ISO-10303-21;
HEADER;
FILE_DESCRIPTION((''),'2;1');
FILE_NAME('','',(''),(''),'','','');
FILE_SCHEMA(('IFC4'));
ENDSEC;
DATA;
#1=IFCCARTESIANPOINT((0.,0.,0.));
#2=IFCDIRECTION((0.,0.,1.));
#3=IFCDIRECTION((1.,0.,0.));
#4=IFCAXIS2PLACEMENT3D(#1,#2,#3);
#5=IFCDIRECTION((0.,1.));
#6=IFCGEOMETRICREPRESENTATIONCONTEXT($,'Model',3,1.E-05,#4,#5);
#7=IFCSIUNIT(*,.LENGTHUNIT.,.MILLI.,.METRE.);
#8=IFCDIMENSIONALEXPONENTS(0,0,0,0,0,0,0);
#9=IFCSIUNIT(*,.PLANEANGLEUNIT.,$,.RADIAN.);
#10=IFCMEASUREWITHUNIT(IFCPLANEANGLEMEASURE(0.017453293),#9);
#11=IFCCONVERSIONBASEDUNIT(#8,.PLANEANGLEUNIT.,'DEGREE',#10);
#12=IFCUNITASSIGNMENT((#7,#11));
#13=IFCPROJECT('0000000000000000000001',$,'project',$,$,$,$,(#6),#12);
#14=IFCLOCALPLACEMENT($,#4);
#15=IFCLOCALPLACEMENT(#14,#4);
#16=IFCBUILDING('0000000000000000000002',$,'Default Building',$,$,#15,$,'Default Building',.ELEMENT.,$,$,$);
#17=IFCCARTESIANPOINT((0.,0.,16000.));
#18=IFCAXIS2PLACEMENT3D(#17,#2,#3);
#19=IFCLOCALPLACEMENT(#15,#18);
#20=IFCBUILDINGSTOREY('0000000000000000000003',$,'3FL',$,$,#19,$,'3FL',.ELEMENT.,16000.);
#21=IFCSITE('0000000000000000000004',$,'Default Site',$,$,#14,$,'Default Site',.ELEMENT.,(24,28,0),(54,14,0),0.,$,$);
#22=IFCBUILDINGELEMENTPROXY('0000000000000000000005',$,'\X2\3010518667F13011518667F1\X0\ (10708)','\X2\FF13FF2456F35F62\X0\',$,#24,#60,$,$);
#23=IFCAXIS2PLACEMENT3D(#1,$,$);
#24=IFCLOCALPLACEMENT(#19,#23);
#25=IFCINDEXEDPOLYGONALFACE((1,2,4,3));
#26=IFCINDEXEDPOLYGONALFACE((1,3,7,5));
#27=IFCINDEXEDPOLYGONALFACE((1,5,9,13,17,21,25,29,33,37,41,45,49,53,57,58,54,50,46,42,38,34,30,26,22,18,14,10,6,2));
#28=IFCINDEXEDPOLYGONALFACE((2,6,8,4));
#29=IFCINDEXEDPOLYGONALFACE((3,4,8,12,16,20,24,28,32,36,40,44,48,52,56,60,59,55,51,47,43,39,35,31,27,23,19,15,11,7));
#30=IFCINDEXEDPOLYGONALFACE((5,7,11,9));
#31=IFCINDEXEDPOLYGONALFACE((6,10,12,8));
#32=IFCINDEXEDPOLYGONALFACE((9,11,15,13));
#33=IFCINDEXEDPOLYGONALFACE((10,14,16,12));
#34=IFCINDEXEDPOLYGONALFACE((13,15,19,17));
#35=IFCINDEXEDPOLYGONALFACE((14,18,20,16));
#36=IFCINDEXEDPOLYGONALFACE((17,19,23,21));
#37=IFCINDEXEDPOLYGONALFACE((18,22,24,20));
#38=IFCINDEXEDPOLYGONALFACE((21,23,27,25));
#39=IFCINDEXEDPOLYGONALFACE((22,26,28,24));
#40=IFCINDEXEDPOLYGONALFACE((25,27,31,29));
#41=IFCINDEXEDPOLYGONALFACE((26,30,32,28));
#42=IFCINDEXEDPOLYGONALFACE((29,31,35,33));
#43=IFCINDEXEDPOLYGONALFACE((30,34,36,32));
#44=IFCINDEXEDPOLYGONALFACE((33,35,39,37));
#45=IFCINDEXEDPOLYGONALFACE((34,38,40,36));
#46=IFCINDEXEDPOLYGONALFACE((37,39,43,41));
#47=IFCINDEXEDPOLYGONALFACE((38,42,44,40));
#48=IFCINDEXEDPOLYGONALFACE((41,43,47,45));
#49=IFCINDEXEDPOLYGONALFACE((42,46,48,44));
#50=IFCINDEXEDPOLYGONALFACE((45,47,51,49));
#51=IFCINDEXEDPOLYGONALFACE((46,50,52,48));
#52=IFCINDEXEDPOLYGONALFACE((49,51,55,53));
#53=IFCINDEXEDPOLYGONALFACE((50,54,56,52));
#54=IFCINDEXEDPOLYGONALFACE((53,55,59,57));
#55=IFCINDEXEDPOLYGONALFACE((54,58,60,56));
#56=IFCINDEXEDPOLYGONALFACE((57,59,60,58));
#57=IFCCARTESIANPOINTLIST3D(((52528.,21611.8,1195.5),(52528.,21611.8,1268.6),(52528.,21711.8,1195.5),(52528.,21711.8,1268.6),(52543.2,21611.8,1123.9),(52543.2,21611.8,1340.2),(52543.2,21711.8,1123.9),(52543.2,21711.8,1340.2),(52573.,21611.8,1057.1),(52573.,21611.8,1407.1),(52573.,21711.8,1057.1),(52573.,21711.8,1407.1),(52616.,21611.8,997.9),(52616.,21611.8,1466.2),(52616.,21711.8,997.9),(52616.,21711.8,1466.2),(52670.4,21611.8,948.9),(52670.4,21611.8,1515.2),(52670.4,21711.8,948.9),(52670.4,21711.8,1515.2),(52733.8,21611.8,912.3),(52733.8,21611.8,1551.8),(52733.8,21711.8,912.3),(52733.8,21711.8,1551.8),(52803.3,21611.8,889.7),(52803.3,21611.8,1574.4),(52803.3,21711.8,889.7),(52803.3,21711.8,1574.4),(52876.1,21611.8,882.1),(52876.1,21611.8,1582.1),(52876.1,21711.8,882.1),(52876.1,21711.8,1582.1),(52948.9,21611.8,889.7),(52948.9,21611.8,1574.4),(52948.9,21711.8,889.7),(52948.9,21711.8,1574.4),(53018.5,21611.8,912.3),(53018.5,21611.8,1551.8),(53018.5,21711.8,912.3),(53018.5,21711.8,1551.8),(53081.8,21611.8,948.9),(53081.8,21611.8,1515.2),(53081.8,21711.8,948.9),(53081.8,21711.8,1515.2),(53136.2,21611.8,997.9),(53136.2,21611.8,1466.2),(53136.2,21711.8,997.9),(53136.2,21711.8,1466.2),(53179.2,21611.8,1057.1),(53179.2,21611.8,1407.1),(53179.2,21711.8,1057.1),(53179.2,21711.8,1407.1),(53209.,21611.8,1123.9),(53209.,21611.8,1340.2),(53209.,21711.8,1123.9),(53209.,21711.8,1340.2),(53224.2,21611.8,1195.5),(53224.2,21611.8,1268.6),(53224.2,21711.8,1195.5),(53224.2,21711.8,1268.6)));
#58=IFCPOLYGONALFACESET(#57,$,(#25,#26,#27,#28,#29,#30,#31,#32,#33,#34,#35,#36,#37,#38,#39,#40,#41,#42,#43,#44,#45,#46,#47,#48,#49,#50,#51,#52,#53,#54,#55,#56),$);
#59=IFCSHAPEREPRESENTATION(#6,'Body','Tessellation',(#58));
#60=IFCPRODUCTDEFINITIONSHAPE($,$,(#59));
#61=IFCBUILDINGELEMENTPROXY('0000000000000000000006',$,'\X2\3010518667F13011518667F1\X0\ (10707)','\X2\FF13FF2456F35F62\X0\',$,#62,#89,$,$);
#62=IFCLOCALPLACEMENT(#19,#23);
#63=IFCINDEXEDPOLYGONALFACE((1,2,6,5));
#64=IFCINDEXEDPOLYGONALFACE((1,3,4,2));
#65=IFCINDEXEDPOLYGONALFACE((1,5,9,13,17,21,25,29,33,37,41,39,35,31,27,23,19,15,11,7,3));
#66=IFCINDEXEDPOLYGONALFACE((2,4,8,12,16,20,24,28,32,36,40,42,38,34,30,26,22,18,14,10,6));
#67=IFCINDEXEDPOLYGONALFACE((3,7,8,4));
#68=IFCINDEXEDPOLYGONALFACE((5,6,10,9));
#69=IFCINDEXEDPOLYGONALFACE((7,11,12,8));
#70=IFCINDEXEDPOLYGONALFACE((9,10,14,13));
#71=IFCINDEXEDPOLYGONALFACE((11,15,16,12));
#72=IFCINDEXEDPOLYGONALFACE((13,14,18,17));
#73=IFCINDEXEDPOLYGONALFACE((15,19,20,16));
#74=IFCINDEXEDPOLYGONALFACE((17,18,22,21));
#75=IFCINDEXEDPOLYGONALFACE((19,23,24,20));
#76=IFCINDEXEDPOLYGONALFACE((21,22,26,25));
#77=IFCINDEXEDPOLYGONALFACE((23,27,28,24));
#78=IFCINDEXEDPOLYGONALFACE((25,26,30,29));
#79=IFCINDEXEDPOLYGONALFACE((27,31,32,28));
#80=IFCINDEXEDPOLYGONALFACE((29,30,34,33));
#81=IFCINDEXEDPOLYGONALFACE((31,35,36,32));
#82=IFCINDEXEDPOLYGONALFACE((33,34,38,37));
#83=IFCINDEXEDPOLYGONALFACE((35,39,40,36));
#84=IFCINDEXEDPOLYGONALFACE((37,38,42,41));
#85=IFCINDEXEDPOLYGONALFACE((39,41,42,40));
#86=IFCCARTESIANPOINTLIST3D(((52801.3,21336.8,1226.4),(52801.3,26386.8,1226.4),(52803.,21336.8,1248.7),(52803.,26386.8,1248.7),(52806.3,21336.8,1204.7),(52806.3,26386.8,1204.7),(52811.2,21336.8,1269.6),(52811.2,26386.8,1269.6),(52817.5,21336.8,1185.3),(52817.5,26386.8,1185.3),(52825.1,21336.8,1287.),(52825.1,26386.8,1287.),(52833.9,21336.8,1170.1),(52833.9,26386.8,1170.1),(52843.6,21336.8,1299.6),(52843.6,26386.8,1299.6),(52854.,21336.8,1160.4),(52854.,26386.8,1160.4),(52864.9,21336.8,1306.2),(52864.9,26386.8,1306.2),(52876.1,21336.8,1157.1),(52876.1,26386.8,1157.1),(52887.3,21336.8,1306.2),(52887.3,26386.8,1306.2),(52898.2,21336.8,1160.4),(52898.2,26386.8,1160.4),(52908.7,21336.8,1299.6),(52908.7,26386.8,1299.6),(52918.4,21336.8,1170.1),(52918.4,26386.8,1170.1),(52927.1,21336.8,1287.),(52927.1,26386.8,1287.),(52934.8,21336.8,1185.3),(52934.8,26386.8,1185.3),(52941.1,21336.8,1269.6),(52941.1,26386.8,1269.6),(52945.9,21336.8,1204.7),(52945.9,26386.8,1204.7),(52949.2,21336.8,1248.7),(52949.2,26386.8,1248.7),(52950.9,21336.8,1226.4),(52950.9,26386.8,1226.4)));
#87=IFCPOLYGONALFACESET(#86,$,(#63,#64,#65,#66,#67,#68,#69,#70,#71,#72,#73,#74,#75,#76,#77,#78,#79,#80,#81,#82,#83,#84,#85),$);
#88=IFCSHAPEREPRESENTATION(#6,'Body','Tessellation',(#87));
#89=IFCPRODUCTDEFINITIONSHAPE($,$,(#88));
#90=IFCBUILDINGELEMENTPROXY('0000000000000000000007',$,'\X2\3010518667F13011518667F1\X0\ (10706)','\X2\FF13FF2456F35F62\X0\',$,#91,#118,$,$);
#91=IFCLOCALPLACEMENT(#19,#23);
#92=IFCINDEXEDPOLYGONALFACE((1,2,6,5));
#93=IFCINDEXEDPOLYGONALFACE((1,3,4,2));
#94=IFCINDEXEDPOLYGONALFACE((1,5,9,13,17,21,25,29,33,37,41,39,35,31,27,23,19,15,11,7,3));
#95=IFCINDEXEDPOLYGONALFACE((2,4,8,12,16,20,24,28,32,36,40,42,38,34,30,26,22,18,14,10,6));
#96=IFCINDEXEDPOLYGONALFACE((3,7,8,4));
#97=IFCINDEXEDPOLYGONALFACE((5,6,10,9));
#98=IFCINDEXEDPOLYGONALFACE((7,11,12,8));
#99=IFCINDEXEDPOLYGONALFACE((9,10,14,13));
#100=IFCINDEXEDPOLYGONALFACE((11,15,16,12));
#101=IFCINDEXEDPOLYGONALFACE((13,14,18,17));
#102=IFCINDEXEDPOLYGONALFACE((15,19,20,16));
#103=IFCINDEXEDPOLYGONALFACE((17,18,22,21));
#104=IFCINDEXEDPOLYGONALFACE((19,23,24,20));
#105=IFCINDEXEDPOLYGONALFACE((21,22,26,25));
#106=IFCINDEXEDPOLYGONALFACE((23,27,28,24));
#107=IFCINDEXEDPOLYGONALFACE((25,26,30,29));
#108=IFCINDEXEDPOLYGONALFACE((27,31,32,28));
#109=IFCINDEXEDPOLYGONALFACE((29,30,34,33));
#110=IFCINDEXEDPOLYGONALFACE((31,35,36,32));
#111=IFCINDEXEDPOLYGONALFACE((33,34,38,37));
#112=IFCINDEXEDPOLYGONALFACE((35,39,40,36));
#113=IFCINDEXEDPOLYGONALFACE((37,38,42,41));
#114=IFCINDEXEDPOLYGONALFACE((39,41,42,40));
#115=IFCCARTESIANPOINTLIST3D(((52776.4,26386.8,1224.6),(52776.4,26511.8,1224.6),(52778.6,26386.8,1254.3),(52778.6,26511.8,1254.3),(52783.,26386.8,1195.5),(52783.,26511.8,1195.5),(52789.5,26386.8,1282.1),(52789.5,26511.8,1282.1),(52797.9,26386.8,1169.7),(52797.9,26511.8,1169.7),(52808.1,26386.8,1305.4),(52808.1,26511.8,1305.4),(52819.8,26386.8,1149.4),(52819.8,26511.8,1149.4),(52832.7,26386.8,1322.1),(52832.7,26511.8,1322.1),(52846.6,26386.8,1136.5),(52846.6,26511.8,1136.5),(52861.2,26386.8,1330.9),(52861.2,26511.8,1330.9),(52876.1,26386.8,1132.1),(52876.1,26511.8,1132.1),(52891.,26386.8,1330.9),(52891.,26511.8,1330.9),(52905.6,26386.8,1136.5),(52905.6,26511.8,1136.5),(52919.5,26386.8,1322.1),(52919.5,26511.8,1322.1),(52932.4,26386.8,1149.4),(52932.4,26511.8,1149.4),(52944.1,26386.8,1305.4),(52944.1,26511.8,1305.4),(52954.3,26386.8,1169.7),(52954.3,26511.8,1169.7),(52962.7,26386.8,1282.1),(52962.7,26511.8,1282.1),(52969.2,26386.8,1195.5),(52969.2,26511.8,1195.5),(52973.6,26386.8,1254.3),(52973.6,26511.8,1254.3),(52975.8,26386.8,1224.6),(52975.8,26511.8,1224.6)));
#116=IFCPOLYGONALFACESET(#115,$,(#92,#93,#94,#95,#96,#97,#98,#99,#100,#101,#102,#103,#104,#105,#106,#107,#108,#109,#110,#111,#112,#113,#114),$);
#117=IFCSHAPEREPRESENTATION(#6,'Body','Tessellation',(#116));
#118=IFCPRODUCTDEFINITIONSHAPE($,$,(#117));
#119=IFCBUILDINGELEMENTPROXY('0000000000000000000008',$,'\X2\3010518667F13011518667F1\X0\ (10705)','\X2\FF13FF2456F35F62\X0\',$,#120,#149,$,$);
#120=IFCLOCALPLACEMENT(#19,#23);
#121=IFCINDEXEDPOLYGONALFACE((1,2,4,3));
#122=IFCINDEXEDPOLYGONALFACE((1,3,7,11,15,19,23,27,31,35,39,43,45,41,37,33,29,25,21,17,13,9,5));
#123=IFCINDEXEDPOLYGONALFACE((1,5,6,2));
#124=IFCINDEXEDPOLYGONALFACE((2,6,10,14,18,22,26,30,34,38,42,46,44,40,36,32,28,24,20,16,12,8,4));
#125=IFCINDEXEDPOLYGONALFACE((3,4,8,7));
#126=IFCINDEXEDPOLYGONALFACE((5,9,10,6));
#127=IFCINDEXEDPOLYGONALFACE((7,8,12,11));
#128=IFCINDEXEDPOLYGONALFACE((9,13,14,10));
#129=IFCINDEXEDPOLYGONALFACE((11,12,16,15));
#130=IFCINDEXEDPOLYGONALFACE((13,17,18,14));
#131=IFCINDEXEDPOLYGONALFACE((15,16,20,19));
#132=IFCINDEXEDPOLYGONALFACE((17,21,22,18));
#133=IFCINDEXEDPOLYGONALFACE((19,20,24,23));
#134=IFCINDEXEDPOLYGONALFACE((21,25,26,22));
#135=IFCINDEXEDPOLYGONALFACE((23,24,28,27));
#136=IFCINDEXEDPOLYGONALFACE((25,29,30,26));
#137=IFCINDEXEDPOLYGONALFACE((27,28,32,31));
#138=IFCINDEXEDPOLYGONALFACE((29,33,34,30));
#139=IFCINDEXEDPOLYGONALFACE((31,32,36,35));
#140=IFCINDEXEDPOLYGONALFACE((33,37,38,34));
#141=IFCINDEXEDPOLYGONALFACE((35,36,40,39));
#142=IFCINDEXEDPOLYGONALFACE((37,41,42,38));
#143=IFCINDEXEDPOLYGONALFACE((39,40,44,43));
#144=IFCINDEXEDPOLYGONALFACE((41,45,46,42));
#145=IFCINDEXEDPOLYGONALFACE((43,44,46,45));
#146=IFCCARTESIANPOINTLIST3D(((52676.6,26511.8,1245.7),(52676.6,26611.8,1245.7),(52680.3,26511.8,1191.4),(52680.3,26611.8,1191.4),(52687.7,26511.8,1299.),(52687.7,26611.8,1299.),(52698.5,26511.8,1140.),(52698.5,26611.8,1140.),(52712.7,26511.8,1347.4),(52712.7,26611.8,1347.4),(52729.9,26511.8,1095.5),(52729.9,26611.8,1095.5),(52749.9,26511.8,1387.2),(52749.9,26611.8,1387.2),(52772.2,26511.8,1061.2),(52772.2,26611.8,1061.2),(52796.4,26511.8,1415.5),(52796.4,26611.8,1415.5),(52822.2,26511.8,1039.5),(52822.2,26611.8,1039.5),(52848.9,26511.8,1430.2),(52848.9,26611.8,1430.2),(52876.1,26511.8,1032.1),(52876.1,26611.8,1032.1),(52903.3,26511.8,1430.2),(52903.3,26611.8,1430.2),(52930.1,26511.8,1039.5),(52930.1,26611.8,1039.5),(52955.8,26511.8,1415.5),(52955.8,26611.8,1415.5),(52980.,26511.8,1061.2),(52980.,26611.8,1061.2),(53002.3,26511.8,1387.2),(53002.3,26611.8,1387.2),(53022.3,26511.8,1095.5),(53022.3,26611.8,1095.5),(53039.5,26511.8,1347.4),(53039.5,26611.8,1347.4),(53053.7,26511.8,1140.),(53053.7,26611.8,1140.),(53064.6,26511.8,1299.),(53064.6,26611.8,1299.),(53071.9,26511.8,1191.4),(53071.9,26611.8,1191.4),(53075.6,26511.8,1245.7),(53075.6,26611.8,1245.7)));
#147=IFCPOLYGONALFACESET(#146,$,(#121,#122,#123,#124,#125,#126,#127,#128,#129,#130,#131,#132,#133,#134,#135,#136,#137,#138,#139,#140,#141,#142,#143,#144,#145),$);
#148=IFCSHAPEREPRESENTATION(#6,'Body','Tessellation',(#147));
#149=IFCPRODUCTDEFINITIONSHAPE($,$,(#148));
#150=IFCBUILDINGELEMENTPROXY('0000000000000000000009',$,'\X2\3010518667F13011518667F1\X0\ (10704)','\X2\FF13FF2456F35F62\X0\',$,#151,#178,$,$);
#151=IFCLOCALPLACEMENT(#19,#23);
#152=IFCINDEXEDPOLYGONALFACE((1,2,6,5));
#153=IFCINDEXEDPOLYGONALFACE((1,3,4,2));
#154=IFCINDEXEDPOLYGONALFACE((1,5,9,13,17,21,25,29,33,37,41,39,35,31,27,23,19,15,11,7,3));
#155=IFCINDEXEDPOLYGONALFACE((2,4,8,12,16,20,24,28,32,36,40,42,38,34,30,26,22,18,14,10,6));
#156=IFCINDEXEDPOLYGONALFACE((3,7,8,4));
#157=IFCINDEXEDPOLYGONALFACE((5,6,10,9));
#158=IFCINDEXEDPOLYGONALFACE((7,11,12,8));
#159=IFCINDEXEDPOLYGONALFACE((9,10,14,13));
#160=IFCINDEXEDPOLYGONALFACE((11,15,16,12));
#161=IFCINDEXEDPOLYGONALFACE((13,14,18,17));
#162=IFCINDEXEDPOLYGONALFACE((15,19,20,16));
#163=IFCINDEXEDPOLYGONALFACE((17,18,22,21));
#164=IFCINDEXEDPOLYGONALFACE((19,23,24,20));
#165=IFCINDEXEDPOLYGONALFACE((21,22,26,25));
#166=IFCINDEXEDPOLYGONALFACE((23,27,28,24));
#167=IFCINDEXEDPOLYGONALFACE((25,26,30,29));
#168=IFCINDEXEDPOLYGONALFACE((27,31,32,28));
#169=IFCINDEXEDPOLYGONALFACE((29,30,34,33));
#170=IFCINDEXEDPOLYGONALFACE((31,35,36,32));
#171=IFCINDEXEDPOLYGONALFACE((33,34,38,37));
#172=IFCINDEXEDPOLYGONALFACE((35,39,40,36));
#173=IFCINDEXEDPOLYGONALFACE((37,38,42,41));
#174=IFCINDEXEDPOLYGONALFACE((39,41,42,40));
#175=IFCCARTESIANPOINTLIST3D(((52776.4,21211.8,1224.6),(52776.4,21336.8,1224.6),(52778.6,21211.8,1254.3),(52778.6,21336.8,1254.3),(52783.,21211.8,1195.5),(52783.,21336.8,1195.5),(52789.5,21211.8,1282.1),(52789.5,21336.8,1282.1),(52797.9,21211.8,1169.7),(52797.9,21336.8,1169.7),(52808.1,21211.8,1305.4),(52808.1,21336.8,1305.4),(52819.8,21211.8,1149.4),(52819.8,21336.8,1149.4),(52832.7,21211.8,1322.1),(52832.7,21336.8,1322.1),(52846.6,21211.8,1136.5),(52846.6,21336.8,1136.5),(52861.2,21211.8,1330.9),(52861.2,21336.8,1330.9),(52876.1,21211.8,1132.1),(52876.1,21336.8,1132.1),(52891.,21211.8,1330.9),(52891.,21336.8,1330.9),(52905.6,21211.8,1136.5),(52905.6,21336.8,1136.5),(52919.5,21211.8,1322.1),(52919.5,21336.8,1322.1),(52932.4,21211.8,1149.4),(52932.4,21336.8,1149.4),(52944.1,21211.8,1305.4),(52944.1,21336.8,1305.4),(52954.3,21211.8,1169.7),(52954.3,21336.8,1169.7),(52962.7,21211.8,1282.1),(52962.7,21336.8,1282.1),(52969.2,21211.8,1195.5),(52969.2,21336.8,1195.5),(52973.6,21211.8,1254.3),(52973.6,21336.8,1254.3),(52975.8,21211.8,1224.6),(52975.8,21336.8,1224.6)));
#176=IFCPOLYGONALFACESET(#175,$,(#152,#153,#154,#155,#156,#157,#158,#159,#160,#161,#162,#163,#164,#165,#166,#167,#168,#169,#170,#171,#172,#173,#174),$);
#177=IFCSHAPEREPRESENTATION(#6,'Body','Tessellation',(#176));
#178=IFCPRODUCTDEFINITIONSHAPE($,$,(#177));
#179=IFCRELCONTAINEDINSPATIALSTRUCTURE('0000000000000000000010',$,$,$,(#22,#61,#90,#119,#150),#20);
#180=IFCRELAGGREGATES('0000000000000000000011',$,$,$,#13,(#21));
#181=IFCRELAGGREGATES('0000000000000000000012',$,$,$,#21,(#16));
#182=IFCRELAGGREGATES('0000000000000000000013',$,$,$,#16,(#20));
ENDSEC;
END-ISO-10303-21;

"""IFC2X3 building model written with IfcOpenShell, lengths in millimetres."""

from ifc_helpers import new_model, entity, si_unit, converted_unit, direction, frame, origin_with_axes, origin_2d_with_axis, place, context, project, spatial, circle, extrude, source, transform, mapped, element, save


model = new_model("IFC2X3")

# Units and contexts
model_context = context("Model", 3, precision=1e-05, world=origin_with_axes(), true_north=direction((0.0, 1.0)))
ifc_project = project(units=[si_unit("LENGTHUNIT", "METRE", prefix="MILLI"), converted_unit("PLANEANGLEUNIT", "DEGREE", entity("IfcPlaneAngleMeasure", 0.017453293), si_unit("PLANEANGLEUNIT", "RADIAN"), dimensions=[0, 0, 0, 0, 0, 0, 0])], contexts=[model_context])

# Site, building, storey
site_placement = place(None, origin_with_axes())
site = spatial("IfcSite", under=ifc_project, at=site_placement, Name="Default Site", LongName="Default Site", CompositionType="ELEMENT", RefLatitude=(24, 28, 0), RefLongitude=(54, 14, 0), RefElevation=0.0)
building_placement = place(site_placement, origin_with_axes())
building = spatial("IfcBuilding", under=site, at=building_placement, Name="Default Building", LongName="Default Building", CompositionType="ELEMENT")
storey_placement = place(building_placement, frame((0.0, 0.0, 16000.0), z_axis=(0.0, 0.0, 1.0), x_axis=(1.0, 0.0, 0.0)))
storey = spatial("IfcBuildingStorey", under=building, at=storey_placement, Name="3FL", LongName="3FL", CompositionType="ELEMENT", Elevation=16000.0)

# Building element proxies
shared_shape_1 = source(origin_with_axes(), model_context, "Body", "SweptSolid", [
    extrude(circle(Radius=350.0, at=origin_2d_with_axis()), frame((0.0, 0.0, 0.0), z_axis=(0.0, 0.0, 1.0), x_axis=(1.0, 0.0, 0.0)), (0.0, 0.0, 1.0), 100.0),
])
proxy_1_placement = place(storey_placement, frame((52876.1, 21611.8, 1232.1), z_axis=(0.0, 1.0, 0.0), x_axis=(0.0, 0.0, -1.0)))
element("IfcBuildingElementProxy", 1, at=proxy_1_placement, inside=storey, Name="【円柱】円柱 (10708)", Description="３Ｄ図形", context=model_context, shape_type="MappedRepresentation", body=[
    mapped(shared_shape_1, transform((0.0, 0.0, 0.0))),
])
shared_shape_2 = source(origin_with_axes(), model_context, "Body", "SweptSolid", [
    extrude(circle(Radius=75.0, at=origin_2d_with_axis()), frame((0.0, 0.0, 0.0), z_axis=(0.0, 0.0, 1.0), x_axis=(1.0, 0.0, 0.0)), (0.0, 0.0, 1.0), 5050.0),
])
proxy_2_placement = place(storey_placement, frame((52876.1, 21336.8, 1232.1), z_axis=(0.0, 1.0, 0.0), x_axis=(0.0, 0.0, -1.0)))
element("IfcBuildingElementProxy", 2, at=proxy_2_placement, inside=storey, Name="【円柱】円柱 (10707)", Description="３Ｄ図形", context=model_context, shape_type="MappedRepresentation", body=[
    mapped(shared_shape_2, transform((0.0, 0.0, 0.0))),
])
shared_shape_3 = source(origin_with_axes(), model_context, "Body", "SweptSolid", [
    extrude(circle(Radius=100.0, at=origin_2d_with_axis()), frame((0.0, 0.0, 0.0), z_axis=(0.0, 0.0, 1.0), x_axis=(1.0, 0.0, 0.0)), (0.0, 0.0, 1.0), 125.0),
])
proxy_3_placement = place(storey_placement, frame((52876.1, 26386.8, 1232.1), z_axis=(0.0, 1.0, 0.0), x_axis=(0.0, 0.0, -1.0)))
element("IfcBuildingElementProxy", 3, at=proxy_3_placement, inside=storey, Name="【円柱】円柱 (10706)", Description="３Ｄ図形", context=model_context, shape_type="MappedRepresentation", body=[
    mapped(shared_shape_3, transform((0.0, 0.0, 0.0))),
])
shared_shape_4 = source(origin_with_axes(), model_context, "Body", "SweptSolid", [
    extrude(circle(Radius=200.0, at=origin_2d_with_axis()), frame((0.0, 0.0, 0.0), z_axis=(0.0, 0.0, 1.0), x_axis=(1.0, 0.0, 0.0)), (0.0, 0.0, 1.0), 100.0),
])
proxy_4_placement = place(storey_placement, frame((52876.1, 26511.8, 1232.1), z_axis=(0.0, 1.0, 0.0), x_axis=(0.0, 0.0, -1.0)))
element("IfcBuildingElementProxy", 4, at=proxy_4_placement, inside=storey, Name="【円柱】円柱 (10705)", Description="３Ｄ図形", context=model_context, shape_type="MappedRepresentation", body=[
    mapped(shared_shape_4, transform((0.0, 0.0, 0.0))),
])
shared_shape_5 = source(origin_with_axes(), model_context, "Body", "SweptSolid", [
    extrude(circle(Radius=100.0, at=origin_2d_with_axis()), frame((0.0, 0.0, 0.0), z_axis=(0.0, 0.0, 1.0), x_axis=(1.0, 0.0, 0.0)), (0.0, 0.0, 1.0), 125.0),
])
proxy_5_placement = place(storey_placement, frame((52876.1, 21211.8, 1232.1), z_axis=(0.0, 1.0, 0.0), x_axis=(0.0, 0.0, -1.0)))
element("IfcBuildingElementProxy", 5, at=proxy_5_placement, inside=storey, Name="【円柱】円柱 (10704)", Description="３Ｄ図形", context=model_context, shape_type="MappedRepresentation", body=[
    mapped(shared_shape_5, transform((0.0, 0.0, 0.0))),
])

save(model, "model.ifc")
